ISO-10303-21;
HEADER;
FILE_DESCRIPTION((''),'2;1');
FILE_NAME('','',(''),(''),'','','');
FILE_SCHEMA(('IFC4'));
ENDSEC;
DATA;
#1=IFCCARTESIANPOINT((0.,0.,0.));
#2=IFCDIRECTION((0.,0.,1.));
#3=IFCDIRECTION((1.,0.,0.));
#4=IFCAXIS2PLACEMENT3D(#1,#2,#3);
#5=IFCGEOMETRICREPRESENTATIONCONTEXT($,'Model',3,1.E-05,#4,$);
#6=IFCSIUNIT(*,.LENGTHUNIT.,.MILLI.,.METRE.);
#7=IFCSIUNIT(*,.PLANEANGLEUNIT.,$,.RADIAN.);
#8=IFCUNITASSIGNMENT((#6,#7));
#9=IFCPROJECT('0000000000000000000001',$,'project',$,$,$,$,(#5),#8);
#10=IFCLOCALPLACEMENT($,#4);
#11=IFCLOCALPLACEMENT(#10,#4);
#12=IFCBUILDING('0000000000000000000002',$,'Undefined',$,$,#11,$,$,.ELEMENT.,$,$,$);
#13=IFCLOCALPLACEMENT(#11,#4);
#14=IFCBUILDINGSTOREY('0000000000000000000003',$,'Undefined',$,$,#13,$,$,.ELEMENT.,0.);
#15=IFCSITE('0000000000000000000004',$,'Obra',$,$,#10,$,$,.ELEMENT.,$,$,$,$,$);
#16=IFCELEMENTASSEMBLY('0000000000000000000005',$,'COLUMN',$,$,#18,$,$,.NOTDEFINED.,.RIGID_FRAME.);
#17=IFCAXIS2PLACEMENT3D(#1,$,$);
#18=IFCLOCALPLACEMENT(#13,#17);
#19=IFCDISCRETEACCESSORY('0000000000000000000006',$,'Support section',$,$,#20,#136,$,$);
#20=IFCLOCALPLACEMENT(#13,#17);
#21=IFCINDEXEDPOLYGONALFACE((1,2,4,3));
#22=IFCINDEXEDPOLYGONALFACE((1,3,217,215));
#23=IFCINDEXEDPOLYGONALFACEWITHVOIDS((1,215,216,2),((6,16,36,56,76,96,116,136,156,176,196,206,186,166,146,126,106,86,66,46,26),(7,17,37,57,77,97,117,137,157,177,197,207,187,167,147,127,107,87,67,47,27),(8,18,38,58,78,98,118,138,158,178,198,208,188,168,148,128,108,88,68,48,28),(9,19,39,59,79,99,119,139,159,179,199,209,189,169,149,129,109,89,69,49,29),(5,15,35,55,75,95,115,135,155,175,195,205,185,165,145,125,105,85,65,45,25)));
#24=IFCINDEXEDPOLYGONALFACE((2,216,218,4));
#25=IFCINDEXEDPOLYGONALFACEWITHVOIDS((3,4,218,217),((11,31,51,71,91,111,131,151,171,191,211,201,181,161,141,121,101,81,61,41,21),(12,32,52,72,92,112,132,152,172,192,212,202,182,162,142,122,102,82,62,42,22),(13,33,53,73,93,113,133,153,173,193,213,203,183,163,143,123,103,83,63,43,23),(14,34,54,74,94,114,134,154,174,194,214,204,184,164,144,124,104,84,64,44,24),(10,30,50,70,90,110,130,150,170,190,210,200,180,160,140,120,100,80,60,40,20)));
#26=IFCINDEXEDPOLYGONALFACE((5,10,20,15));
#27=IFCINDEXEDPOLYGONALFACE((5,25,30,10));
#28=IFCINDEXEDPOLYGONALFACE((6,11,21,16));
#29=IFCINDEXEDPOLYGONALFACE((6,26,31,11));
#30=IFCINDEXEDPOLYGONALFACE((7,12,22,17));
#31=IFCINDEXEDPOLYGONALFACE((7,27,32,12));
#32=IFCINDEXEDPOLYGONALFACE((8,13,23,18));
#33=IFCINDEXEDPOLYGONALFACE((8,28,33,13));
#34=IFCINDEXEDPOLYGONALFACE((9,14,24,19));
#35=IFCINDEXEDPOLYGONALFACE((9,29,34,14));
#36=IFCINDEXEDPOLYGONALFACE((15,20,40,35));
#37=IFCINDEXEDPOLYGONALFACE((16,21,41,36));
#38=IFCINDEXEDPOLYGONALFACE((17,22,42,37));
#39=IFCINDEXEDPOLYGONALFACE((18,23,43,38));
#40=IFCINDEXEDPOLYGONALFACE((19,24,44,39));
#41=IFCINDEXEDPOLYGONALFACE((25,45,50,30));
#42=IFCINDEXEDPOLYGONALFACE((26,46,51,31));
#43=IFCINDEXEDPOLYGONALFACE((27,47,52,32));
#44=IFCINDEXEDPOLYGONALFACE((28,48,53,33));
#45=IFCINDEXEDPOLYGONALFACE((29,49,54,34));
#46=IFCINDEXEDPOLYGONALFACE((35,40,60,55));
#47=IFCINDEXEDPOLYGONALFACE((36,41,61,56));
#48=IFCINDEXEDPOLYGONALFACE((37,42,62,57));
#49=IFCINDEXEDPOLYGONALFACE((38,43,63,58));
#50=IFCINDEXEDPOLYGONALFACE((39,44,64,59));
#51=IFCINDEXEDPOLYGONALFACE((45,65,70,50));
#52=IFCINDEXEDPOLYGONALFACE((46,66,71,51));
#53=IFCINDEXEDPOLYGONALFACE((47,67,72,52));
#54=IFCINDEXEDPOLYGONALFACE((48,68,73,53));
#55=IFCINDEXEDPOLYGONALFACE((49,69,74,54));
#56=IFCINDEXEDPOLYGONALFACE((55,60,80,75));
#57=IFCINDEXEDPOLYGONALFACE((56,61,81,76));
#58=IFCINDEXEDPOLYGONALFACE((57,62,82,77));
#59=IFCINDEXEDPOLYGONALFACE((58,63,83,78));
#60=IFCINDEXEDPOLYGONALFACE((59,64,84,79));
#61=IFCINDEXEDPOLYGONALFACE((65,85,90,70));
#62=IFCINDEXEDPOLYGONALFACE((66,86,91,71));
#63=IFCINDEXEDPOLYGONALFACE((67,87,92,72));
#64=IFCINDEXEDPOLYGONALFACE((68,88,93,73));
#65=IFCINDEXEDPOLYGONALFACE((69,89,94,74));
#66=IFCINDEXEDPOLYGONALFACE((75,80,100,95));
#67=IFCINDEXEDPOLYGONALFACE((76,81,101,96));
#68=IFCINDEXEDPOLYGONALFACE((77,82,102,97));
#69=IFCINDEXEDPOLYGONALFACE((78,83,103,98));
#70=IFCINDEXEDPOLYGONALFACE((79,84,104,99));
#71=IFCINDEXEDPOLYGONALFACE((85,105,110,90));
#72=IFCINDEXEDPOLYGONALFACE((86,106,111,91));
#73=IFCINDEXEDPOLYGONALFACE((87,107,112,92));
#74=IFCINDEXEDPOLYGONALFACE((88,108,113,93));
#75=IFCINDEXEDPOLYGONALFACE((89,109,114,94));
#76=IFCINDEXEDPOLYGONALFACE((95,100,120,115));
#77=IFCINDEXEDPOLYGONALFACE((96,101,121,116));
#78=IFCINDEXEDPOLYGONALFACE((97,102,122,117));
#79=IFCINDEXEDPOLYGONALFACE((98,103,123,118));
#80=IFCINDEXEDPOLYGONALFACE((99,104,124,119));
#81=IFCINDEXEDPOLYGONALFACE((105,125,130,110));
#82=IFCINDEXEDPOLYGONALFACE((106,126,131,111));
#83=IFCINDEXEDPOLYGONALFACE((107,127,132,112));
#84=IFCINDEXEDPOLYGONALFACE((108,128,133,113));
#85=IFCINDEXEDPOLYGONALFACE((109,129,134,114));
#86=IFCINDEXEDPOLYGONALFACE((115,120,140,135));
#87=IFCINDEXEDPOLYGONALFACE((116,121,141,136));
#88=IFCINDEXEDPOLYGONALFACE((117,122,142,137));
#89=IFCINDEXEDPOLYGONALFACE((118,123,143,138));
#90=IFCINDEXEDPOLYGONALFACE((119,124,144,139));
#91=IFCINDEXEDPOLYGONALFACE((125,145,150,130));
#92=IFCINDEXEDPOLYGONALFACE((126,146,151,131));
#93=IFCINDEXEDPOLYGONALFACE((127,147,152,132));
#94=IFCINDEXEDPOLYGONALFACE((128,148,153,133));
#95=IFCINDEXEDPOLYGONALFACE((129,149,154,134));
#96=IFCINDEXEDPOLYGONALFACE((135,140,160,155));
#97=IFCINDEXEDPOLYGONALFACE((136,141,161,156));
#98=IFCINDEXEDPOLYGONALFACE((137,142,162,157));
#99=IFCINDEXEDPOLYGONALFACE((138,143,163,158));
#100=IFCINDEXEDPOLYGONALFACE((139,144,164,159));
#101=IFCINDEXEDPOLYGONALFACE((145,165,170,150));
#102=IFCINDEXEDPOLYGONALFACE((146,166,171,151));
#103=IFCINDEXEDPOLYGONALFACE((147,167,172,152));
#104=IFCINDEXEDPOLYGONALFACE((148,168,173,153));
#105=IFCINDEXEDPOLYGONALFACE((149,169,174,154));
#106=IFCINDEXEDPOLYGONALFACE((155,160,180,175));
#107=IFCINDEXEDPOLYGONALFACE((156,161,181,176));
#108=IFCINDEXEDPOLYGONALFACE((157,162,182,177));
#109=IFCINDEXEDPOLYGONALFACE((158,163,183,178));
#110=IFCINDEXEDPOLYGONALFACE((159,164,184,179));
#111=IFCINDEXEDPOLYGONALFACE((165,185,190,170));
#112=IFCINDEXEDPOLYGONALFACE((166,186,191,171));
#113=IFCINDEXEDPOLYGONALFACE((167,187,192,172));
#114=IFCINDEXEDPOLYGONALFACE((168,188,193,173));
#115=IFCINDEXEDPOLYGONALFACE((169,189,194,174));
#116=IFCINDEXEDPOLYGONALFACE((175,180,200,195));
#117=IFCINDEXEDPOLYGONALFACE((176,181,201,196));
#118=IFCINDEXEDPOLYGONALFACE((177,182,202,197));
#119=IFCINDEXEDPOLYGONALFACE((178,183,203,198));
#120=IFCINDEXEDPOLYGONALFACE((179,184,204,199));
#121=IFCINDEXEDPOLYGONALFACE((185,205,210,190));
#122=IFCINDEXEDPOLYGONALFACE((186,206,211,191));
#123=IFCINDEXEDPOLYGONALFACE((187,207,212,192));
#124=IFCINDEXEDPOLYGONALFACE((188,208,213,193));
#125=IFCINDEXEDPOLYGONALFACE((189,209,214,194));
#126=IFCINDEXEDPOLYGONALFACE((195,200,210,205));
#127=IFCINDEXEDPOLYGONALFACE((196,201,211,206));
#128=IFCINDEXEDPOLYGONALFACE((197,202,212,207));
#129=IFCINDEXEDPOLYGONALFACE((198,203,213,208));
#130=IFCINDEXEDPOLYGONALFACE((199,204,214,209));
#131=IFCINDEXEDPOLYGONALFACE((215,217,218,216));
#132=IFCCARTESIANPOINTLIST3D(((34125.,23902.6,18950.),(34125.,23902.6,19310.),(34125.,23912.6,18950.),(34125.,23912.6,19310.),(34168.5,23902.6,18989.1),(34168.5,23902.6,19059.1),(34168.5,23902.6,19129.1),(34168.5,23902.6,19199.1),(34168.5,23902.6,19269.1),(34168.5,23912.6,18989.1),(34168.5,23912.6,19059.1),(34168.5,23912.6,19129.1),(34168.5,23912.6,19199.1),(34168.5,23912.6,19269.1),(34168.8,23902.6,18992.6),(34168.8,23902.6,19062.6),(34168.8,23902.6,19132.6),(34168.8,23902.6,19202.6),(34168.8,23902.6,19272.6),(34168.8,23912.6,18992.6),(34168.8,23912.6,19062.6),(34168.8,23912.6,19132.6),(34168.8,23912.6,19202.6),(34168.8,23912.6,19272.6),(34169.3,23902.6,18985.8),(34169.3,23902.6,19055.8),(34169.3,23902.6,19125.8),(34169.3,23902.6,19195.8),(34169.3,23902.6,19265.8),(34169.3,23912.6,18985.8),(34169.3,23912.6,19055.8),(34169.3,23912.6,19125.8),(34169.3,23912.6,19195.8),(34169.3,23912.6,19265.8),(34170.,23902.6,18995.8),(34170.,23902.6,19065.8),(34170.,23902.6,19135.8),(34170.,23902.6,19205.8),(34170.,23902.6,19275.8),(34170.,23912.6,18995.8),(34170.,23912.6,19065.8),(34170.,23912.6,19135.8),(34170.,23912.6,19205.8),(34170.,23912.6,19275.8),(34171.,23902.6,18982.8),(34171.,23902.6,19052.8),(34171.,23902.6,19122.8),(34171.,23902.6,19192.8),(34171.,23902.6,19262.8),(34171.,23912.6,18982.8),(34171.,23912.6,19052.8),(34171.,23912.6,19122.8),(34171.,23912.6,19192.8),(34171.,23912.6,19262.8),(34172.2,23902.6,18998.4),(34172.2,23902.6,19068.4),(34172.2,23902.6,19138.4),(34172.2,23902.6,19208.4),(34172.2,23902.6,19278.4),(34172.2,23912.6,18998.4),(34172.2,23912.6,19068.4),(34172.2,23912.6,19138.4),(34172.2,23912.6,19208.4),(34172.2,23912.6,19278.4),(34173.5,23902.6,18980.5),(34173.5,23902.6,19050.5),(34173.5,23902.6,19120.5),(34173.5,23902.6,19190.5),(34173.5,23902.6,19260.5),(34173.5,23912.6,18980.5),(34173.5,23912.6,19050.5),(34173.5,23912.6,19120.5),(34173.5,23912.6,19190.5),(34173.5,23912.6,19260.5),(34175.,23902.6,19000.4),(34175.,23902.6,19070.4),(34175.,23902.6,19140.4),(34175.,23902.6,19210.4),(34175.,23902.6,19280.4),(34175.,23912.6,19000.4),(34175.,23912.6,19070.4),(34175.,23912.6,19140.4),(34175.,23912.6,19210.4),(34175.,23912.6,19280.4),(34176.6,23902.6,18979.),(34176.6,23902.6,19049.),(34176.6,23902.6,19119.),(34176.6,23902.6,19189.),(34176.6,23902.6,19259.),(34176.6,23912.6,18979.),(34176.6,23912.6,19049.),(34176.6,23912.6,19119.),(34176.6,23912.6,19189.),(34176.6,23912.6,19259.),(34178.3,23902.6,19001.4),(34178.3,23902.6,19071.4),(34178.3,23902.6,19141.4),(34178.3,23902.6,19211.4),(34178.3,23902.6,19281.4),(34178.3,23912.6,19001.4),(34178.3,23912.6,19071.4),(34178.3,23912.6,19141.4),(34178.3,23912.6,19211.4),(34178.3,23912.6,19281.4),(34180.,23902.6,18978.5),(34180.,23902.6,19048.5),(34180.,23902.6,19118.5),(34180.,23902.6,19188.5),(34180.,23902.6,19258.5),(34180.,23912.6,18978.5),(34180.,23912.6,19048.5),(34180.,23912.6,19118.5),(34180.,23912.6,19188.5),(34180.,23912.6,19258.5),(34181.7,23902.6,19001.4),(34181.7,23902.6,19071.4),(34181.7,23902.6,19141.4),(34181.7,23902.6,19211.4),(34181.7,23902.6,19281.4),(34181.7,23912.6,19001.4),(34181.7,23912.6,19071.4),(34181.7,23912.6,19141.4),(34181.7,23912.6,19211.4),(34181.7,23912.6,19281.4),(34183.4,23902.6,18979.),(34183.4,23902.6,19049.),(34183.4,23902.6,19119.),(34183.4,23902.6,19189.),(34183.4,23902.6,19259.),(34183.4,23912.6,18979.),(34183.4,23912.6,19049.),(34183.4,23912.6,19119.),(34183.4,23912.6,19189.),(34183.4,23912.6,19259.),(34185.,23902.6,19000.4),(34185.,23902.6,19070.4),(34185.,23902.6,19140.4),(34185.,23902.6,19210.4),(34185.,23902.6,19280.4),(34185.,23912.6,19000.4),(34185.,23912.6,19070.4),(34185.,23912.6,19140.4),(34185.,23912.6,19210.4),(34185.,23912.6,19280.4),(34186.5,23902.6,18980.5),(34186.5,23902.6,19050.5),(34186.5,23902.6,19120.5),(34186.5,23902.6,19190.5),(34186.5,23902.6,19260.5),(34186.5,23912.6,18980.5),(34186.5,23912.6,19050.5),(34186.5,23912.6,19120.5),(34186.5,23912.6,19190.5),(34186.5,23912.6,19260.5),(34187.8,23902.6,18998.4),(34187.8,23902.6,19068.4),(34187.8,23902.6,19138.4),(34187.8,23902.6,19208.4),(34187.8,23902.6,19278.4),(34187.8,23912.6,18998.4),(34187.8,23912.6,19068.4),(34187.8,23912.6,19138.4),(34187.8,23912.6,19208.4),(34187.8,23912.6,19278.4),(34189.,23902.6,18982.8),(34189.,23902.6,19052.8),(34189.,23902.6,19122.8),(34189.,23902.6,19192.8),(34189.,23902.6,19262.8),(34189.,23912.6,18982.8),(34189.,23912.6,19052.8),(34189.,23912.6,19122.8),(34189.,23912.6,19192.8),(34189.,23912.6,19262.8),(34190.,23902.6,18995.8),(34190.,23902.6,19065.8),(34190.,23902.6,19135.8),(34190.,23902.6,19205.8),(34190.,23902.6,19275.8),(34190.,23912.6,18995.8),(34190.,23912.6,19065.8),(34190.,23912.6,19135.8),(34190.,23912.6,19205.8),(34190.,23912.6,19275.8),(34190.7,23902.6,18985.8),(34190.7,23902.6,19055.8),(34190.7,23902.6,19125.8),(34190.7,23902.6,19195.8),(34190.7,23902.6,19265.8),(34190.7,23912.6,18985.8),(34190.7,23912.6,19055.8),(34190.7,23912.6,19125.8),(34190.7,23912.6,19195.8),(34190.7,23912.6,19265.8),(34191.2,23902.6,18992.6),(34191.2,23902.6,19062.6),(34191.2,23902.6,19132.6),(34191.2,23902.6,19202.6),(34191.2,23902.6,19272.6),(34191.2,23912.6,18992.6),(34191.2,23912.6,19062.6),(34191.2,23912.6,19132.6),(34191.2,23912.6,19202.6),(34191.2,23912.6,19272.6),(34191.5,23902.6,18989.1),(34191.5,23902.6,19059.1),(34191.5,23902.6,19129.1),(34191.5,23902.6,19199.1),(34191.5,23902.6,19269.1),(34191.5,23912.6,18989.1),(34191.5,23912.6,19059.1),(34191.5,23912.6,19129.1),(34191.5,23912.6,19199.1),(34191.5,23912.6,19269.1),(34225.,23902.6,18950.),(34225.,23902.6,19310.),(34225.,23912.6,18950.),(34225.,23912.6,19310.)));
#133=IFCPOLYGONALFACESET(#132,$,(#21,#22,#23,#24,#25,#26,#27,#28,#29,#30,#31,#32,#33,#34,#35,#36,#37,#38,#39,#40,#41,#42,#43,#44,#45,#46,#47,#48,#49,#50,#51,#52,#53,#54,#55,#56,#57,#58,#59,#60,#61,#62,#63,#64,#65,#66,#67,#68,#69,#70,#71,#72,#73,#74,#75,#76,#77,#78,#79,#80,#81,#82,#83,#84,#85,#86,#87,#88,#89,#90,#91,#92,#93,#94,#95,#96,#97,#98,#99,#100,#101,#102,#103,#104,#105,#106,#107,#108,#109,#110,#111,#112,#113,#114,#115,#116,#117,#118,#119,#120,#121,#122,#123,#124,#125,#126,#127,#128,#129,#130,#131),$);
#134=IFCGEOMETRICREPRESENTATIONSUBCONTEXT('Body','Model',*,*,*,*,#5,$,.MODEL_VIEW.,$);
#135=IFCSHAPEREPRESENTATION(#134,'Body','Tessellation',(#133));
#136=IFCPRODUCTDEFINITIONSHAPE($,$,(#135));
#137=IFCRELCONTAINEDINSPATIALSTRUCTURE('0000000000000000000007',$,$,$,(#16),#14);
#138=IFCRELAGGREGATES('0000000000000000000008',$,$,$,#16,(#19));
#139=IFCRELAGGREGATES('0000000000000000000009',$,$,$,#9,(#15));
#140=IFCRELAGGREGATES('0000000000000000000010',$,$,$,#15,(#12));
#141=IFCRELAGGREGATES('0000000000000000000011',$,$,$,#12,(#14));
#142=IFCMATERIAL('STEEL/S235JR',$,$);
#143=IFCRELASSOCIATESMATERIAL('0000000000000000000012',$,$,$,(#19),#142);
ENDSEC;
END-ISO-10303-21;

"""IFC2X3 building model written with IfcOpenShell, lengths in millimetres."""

from ifc_helpers import new_model, si_unit, frame, origin_with_axes, origin_2d_with_axis, place, context, subcontext, project, spatial, rectangle, circle, extrude, source, transform, mapped, material, element, aggregate, save


model = new_model("IFC2X3")

# Units and contexts
model_context = context("Model", 3, precision=1e-05, world=origin_with_axes())
body_context = subcontext(model_context, "Body", "Model", "MODEL_VIEW")
ifc_project = project(units=[si_unit("LENGTHUNIT", "METRE", prefix="MILLI"), si_unit("PLANEANGLEUNIT", "RADIAN")], contexts=[model_context])

# Site, building, storey
site_placement = place(None, origin_with_axes())
site = spatial("IfcSite", under=ifc_project, at=site_placement, Name="Obra", CompositionType="ELEMENT")
building_placement = place(site_placement, origin_with_axes())
building = spatial("IfcBuilding", under=site, at=building_placement, Name="Undefined", CompositionType="ELEMENT")
storey_placement = place(building_placement, origin_with_axes())
storey = spatial("IfcBuildingStorey", under=building, at=storey_placement, Name="Undefined", CompositionType="ELEMENT", Elevation=0.0)

# Element assembly
ifc_material_1 = material(Name="STEEL/S235JR")
assembly_1_placement = place(storey_placement, origin_with_axes())
assembly_1 = element("IfcElementAssembly", 1, at=assembly_1_placement, inside=storey, Name="COLUMN", AssemblyPlace="NOTDEFINED", PredefinedType="RIGID_FRAME")

# Discrete accessory, opening
discrete_accessory_1_placement = place(assembly_1_placement, frame((34175.0, 23907.6, 18950.0), z_axis=(0.0, 0.0, 1.0), x_axis=(-1.0, 0.0, 0.0)))
discrete_accessory_1 = element("IfcDiscreteAccessory", 2, at=discrete_accessory_1_placement, material=ifc_material_1, Name="Support section", context=body_context, shape_type="SweptSolid", body=[
    extrude(rectangle(XDim=10.0, YDim=100.0, at=origin_2d_with_axis()), frame((0.0, 0.0, 360.0), z_axis=(0.0, 0.0, -1.0), x_axis=(0.0, 1.0, 0.0)), (0.0, 0.0, 1.0), 360.0),
])
shared_shape_1 = source(origin_with_axes(), body_context, "Body", "SweptSolid", [
    extrude(circle(Radius=11.5, at=origin_2d_with_axis()), frame((0.0, 5.7, 0.0), z_axis=(0.0, 1.0, 0.0), x_axis=(1.0, 0.0, 0.0)), (0.0, 0.0, 1.0), 10.2),
])
opening_1_placement = place(assembly_1_placement, frame((34135.0, 23896.9, 19350.0), z_axis=(1.0, 0.0, 0.0), x_axis=(0.0, 0.0, -1.0)))
element("IfcOpeningElement", 3, at=opening_1_placement, cuts=discrete_accessory_1, ObjectType="Opening", context=body_context, shape_type="MappedRepresentation", body=[
    mapped(shared_shape_1, transform((80.0, 0.0, 45.0))),
    mapped(shared_shape_1, transform((150.0, 0.0, 45.0))),
    mapped(shared_shape_1, transform((220.0, 0.0, 45.0))),
    mapped(shared_shape_1, transform((290.0, 0.0, 45.0))),
    mapped(shared_shape_1, transform((360.0, 0.0, 45.0))),
])

aggregate(assembly_1, [discrete_accessory_1])

save(model, "model.ifc")
